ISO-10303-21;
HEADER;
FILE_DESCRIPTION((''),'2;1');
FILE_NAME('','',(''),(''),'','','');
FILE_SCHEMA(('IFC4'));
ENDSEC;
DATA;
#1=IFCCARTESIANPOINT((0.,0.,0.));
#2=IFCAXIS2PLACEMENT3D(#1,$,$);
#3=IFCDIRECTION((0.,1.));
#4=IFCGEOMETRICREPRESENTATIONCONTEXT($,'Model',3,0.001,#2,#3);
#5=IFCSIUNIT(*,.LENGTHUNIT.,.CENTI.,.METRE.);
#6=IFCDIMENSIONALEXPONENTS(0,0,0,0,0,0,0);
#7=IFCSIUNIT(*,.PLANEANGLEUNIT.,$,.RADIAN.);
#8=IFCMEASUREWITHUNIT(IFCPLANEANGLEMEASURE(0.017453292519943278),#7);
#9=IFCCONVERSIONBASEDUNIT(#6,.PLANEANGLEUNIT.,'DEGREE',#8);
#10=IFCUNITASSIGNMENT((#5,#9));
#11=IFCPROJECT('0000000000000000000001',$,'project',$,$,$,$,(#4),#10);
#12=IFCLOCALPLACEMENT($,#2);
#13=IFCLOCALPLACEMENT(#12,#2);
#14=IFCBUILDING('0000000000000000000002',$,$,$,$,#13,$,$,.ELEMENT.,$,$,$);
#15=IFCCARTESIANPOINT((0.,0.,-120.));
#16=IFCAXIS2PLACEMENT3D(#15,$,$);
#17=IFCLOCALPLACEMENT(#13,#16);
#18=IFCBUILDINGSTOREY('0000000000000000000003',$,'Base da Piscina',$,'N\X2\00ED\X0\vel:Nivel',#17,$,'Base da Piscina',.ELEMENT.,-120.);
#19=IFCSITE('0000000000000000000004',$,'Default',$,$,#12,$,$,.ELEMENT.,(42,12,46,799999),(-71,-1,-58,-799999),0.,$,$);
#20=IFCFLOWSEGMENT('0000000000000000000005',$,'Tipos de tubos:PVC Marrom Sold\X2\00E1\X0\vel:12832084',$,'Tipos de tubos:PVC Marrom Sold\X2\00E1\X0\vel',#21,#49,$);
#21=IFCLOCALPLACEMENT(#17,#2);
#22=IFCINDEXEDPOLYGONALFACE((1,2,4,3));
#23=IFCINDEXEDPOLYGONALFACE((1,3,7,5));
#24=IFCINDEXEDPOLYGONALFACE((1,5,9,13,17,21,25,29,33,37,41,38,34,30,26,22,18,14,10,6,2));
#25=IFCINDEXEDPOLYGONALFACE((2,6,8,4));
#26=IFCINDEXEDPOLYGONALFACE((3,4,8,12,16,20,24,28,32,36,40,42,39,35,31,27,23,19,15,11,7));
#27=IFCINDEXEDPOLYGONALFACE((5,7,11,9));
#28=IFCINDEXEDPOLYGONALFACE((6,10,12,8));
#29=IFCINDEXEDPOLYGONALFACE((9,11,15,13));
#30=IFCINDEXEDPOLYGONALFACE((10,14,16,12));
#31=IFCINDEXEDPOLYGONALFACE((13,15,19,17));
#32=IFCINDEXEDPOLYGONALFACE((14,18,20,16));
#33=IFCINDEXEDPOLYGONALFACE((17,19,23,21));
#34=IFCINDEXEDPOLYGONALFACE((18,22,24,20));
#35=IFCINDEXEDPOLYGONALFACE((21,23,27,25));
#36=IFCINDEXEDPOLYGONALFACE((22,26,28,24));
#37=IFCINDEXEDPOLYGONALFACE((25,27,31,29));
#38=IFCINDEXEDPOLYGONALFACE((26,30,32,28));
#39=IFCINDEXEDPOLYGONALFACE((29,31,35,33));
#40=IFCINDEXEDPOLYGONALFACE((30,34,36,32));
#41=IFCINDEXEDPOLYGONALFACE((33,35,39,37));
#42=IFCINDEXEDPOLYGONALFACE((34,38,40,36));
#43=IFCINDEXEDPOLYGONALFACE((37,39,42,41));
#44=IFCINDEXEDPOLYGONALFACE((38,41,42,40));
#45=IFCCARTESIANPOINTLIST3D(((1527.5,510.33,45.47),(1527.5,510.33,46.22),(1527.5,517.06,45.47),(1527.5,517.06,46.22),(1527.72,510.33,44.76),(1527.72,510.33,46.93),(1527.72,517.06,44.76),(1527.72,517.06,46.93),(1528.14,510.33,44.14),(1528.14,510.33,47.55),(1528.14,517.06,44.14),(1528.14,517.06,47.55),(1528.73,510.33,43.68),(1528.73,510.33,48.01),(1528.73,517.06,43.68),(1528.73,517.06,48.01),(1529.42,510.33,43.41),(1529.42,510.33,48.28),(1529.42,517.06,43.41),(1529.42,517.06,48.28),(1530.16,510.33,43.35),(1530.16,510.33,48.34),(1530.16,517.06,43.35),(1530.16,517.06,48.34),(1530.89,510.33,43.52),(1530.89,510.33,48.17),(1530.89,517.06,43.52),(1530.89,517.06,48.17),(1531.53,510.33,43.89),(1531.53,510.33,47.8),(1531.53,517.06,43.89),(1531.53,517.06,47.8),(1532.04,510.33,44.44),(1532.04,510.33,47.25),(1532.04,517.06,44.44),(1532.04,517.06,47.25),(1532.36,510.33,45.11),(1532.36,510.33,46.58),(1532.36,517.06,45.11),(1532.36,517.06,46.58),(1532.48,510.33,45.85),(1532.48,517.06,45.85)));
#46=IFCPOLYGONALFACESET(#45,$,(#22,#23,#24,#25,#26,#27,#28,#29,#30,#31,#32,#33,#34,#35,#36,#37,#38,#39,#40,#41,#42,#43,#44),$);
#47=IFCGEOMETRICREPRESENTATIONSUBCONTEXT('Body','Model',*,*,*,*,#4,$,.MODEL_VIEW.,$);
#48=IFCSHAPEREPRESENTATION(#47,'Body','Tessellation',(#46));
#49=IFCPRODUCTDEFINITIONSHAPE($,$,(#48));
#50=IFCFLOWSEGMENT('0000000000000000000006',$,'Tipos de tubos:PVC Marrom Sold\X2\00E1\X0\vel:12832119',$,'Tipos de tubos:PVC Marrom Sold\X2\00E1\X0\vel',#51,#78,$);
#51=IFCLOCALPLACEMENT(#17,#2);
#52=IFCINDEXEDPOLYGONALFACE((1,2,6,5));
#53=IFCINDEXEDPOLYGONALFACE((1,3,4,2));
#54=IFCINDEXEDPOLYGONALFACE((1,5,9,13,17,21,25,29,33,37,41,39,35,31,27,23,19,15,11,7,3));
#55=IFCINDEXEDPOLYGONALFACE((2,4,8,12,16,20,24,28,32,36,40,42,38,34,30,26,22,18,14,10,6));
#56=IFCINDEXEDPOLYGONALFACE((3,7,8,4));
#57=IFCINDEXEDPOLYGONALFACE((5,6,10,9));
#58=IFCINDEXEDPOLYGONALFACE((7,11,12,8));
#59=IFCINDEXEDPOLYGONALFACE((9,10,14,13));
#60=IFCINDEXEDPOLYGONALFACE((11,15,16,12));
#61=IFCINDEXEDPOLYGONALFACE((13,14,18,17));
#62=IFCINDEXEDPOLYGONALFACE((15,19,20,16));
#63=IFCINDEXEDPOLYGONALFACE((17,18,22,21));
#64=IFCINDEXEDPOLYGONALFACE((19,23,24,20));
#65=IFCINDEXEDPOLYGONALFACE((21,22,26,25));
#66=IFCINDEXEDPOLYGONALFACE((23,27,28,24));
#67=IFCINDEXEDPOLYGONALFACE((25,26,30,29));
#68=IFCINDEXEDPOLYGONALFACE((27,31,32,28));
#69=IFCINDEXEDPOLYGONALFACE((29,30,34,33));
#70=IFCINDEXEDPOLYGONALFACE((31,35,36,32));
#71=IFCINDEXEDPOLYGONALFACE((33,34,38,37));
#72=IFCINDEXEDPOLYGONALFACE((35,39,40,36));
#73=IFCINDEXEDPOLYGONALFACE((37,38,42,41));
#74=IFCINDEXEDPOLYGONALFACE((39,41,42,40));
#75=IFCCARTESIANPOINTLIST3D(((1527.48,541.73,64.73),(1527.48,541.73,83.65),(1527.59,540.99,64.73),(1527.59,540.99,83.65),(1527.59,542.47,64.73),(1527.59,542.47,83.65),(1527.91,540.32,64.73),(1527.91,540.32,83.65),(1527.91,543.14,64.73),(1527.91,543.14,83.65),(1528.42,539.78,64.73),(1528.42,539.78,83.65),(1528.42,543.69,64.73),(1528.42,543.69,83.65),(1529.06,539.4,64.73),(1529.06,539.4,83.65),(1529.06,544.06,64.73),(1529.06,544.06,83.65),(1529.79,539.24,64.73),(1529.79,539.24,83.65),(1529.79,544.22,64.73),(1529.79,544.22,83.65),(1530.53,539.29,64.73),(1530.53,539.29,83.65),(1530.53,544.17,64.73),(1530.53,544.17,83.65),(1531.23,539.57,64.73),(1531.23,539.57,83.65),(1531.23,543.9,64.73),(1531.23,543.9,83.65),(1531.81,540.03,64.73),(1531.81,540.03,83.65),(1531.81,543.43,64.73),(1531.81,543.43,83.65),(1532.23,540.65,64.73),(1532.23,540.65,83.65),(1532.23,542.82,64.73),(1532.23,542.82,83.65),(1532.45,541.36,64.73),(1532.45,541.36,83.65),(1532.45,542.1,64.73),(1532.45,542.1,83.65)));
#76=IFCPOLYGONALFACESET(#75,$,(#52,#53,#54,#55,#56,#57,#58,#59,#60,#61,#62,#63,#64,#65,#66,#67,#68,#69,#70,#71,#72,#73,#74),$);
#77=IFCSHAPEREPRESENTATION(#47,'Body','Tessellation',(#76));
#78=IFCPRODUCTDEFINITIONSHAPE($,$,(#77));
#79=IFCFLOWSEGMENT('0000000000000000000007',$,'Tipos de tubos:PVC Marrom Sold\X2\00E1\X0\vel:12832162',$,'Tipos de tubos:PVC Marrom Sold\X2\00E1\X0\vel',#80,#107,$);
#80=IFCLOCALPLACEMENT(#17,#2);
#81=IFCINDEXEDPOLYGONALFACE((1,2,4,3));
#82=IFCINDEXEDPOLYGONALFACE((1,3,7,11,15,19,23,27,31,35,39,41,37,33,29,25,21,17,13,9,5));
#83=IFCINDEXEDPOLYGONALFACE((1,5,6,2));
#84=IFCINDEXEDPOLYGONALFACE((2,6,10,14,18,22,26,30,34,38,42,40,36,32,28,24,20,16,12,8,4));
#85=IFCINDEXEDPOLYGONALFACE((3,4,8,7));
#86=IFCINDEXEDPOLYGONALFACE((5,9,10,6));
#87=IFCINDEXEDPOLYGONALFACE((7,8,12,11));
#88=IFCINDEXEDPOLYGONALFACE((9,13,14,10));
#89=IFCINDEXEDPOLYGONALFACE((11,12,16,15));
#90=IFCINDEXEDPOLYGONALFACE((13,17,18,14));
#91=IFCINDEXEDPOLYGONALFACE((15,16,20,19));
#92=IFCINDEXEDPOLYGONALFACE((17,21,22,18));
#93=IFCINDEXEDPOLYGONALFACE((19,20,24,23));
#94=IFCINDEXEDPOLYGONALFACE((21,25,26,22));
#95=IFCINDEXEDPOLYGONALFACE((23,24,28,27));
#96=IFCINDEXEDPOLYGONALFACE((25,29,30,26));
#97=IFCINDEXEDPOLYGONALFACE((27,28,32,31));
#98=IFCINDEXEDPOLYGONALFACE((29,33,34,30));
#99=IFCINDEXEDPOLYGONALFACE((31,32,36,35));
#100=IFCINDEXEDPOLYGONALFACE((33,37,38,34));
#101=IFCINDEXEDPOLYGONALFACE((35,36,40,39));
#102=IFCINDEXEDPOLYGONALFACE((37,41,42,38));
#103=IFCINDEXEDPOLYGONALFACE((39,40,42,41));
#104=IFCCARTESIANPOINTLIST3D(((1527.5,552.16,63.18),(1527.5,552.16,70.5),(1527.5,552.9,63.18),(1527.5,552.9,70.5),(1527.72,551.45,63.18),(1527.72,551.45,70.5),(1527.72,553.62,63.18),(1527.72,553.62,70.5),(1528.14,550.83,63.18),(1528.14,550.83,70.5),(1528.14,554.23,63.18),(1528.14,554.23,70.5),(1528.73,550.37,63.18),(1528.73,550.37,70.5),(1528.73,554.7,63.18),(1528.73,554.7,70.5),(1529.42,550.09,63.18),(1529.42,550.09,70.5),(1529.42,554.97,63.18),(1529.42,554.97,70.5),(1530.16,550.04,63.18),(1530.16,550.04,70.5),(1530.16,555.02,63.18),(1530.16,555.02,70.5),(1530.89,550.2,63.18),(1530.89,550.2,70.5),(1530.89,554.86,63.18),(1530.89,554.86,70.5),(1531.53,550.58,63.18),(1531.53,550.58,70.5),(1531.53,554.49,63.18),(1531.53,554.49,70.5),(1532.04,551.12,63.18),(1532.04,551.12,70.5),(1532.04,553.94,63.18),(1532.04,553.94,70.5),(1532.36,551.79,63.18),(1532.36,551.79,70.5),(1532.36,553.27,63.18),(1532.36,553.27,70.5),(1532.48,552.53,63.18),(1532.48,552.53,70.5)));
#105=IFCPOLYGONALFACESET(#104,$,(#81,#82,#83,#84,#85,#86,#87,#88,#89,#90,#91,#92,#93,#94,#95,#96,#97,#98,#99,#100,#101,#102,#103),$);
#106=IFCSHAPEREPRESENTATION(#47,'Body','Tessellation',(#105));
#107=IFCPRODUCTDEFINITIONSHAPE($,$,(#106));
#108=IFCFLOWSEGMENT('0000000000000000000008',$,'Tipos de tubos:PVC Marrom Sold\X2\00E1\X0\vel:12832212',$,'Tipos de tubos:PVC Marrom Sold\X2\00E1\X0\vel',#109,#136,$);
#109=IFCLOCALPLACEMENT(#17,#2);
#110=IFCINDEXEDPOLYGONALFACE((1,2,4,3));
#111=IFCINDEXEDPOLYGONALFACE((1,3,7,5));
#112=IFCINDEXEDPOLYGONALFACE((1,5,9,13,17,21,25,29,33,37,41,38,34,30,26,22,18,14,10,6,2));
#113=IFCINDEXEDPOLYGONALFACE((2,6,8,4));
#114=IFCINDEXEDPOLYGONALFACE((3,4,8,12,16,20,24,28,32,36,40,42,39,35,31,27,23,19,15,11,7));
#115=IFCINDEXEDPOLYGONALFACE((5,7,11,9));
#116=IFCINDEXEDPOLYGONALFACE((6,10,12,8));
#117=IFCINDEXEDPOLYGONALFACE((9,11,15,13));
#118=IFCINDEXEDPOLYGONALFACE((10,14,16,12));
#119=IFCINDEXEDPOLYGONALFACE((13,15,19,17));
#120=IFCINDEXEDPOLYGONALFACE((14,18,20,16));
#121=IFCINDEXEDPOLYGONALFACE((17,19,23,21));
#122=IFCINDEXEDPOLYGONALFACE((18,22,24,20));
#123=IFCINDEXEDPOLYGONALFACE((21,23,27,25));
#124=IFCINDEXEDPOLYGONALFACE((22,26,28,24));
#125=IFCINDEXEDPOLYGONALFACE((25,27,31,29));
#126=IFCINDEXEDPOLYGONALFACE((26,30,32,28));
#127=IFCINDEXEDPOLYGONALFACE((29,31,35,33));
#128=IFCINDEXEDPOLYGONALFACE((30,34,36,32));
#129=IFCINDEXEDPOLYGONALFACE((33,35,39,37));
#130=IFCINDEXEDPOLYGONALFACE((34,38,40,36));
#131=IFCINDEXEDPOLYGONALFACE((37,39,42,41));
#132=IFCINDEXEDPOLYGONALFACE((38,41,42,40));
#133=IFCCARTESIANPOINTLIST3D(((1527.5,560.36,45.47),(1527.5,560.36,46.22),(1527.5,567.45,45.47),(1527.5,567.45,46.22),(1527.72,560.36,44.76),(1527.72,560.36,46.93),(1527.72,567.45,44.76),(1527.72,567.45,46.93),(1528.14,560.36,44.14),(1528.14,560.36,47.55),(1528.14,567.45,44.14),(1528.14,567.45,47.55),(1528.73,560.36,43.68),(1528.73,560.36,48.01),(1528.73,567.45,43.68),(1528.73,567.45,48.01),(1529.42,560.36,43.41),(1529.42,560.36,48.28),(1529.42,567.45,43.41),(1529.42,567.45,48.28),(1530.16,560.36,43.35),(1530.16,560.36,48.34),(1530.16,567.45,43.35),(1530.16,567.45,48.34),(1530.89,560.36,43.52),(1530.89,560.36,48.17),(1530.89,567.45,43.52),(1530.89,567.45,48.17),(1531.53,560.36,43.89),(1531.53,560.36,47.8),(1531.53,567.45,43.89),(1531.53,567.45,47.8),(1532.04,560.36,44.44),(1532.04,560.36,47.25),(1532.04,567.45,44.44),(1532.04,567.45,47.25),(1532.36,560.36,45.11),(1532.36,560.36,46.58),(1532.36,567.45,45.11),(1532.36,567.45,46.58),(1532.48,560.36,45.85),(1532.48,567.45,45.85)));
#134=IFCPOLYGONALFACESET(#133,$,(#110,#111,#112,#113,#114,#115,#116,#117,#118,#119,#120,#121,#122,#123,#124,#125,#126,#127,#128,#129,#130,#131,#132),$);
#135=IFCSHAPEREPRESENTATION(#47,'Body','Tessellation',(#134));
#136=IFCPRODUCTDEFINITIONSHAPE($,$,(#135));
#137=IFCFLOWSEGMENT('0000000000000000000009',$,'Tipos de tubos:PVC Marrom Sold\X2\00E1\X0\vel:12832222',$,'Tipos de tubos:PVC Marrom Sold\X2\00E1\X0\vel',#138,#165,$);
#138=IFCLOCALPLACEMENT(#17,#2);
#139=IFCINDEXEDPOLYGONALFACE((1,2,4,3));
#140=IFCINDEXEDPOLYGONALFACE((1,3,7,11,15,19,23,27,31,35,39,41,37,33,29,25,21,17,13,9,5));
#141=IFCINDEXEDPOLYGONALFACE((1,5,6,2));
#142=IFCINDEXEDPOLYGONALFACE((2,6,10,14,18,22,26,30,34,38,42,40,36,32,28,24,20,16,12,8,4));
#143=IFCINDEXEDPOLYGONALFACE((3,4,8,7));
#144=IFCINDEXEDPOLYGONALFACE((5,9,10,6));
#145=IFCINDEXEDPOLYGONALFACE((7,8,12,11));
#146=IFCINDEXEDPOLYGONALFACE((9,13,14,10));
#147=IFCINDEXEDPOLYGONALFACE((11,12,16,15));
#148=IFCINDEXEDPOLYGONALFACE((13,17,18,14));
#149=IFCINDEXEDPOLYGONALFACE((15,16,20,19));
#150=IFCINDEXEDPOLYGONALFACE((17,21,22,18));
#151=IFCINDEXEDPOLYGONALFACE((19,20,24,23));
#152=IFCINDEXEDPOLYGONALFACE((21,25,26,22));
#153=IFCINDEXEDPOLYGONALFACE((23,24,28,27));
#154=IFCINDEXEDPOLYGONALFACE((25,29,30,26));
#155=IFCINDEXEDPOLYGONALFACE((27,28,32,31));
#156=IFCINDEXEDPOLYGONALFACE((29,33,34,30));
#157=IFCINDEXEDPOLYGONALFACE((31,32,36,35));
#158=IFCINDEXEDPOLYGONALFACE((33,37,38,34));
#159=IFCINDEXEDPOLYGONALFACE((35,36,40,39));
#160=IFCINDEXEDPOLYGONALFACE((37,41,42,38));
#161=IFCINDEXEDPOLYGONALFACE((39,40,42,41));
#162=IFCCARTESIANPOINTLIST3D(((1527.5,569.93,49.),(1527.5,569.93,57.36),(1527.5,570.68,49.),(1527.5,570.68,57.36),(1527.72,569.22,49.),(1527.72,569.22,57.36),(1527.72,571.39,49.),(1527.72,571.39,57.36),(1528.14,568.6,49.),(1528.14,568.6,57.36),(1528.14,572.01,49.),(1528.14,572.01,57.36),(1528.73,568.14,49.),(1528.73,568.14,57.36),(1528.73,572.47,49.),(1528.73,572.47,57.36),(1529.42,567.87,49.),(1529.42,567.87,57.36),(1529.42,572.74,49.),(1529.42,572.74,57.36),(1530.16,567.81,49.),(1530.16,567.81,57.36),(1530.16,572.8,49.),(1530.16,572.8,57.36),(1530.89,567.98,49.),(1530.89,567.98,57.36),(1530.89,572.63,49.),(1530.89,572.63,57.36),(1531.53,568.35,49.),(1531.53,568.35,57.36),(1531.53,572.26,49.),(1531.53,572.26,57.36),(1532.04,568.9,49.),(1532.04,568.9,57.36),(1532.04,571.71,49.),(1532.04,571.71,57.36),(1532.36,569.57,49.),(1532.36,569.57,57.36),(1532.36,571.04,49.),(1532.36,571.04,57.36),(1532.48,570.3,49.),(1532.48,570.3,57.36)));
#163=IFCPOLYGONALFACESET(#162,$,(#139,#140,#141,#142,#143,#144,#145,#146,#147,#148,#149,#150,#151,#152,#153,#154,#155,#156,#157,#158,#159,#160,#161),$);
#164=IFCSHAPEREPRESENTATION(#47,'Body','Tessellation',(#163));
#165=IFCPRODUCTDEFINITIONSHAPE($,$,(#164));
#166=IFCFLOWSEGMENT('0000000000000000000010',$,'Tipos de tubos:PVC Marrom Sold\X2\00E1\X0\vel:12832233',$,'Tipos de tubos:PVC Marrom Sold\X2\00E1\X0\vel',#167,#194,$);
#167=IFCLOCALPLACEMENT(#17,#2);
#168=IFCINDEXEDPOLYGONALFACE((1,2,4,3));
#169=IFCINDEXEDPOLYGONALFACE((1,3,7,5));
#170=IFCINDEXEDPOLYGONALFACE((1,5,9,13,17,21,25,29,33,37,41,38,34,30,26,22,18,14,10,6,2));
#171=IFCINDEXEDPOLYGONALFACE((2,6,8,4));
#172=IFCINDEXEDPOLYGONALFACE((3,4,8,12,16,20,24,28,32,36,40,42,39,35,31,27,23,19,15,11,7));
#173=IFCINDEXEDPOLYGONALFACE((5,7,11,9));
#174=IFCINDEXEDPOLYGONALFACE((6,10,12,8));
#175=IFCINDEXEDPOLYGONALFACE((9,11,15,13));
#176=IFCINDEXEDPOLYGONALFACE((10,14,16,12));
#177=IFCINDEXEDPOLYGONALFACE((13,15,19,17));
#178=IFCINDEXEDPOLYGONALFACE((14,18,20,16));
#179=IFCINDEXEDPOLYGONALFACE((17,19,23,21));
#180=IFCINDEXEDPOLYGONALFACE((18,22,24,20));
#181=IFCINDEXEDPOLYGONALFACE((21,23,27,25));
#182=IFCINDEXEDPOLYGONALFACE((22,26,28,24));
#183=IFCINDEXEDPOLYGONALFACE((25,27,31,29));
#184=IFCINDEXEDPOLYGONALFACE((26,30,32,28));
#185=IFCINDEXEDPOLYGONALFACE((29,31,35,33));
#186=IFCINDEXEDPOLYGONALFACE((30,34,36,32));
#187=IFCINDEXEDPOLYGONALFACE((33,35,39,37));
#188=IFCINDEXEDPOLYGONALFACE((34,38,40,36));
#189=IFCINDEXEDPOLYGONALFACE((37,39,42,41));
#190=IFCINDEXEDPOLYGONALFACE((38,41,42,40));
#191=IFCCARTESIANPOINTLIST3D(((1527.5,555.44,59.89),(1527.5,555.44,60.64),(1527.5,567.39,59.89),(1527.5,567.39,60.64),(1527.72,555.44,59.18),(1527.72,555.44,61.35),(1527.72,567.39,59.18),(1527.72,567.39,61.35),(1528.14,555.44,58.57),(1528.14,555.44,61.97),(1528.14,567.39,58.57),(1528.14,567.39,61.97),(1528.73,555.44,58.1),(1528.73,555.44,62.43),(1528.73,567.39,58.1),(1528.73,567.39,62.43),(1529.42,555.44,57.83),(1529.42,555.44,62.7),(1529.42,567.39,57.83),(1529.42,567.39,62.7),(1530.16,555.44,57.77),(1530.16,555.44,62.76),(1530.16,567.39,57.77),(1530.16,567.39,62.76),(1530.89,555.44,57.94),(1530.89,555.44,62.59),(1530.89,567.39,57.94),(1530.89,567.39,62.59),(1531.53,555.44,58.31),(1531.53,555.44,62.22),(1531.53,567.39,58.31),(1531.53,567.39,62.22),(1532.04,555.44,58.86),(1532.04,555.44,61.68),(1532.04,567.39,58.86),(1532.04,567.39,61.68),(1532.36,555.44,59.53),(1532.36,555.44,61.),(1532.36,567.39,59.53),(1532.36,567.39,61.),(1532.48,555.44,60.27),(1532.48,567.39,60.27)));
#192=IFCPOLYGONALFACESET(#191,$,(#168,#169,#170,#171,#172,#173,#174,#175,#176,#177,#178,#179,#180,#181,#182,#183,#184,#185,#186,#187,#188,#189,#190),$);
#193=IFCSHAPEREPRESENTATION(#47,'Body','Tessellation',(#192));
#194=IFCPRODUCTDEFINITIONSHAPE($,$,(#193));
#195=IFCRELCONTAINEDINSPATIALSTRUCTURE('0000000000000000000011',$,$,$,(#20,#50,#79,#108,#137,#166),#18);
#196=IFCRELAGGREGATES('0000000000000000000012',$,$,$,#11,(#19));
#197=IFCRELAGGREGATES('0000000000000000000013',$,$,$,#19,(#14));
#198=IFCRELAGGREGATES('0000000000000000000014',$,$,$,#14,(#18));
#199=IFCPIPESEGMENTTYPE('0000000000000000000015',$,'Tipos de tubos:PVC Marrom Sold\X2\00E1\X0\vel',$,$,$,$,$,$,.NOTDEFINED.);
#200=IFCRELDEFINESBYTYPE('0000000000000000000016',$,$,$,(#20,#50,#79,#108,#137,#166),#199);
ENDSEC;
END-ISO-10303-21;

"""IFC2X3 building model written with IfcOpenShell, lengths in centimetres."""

from ifc_helpers import new_model, entity, si_unit, converted_unit, direction, frame, frame_2d, origin, origin_2d_with_axis, place, context, subcontext, project, spatial, circle, extrude, type_object, element, save


model = new_model("IFC2X3")

# Units and contexts
model_context = context("Model", 3, precision=0.001, world=origin(), true_north=direction((0.0, 1.0)))
body_context = subcontext(model_context, "Body", "Model", "MODEL_VIEW")
ifc_project = project(units=[si_unit("LENGTHUNIT", "METRE", prefix="CENTI"), converted_unit("PLANEANGLEUNIT", "DEGREE", entity("IfcPlaneAngleMeasure", 0.017453292519943278), si_unit("PLANEANGLEUNIT", "RADIAN"), dimensions=[0, 0, 0, 0, 0, 0, 0])], contexts=[model_context])

# Site, building, storey
site_placement = place(None, origin())
site = spatial("IfcSite", under=ifc_project, at=site_placement, Name="Default", CompositionType="ELEMENT", RefLatitude=(42, 12, 46, 799999), RefLongitude=(-71, -1, -58, -799999), RefElevation=0.0)
building_placement = place(site_placement, origin())
building = spatial("IfcBuilding", under=site, at=building_placement, CompositionType="ELEMENT")
storey_placement = place(building_placement, frame((0.0, 0.0, -120.0)))
storey = spatial("IfcBuildingStorey", under=building, at=storey_placement, Name="Base da Piscina", ObjectType="Nível:Nivel", LongName="Base da Piscina", CompositionType="ELEMENT", Elevation=-120.0)

# Flow segments
pipe_segment_type = type_object("IfcPipeSegmentType", Name="Tipos de tubos:PVC Marrom Soldável", PredefinedType="NOTDEFINED")
flow_segment_1_placement = place(storey_placement, origin())
element("IfcFlowSegment", 1, at=flow_segment_1_placement, inside=storey, type_object=pipe_segment_type, Name="Tipos de tubos:PVC Marrom Soldável:12832084", ObjectType="Tipos de tubos:PVC Marrom Soldável", context=body_context, shape_type="SweptSolid", body=[
    extrude(circle(Radius=2.5, at=origin_2d_with_axis()), frame((1529.98, 510.33, 45.85), z_axis=(0.0, 1.0, 0.0), x_axis=(1.0, 0.0, 0.0)), (0.0, 0.0, 1.0), 6.74),
])
flow_segment_2_placement = place(storey_placement, origin())
element("IfcFlowSegment", 2, at=flow_segment_2_placement, inside=storey, type_object=pipe_segment_type, Name="Tipos de tubos:PVC Marrom Soldável:12832119", ObjectType="Tipos de tubos:PVC Marrom Soldável", context=body_context, shape_type="SweptSolid", body=[
    extrude(circle(Radius=2.5, at=origin_2d_with_axis()), frame((1529.98, 541.73, 64.73), z_axis=(0.0, 0.0, 1.0), x_axis=(-1.0, 0.0, 0.0)), (0.0, 0.0, 1.0), 18.91),
])
flow_segment_3_placement = place(storey_placement, origin())
element("IfcFlowSegment", 3, at=flow_segment_3_placement, inside=storey, type_object=pipe_segment_type, Name="Tipos de tubos:PVC Marrom Soldável:12832162", ObjectType="Tipos de tubos:PVC Marrom Soldável", context=body_context, shape_type="SweptSolid", body=[
    extrude(circle(Radius=2.5, at=origin_2d_with_axis()), frame((1529.98, 552.53, 63.18)), (0.0, 0.0, 1.0), 7.32),
])
flow_segment_4_placement = place(storey_placement, origin())
element("IfcFlowSegment", 4, at=flow_segment_4_placement, inside=storey, type_object=pipe_segment_type, Name="Tipos de tubos:PVC Marrom Soldável:12832212", ObjectType="Tipos de tubos:PVC Marrom Soldável", context=body_context, shape_type="SweptSolid", body=[
    extrude(circle(Radius=2.5, at=origin_2d_with_axis()), frame((1529.98, 560.36, 45.85), z_axis=(0.0, 1.0, 0.0), x_axis=(1.0, 0.0, 0.0)), (0.0, 0.0, 1.0), 7.09),
])
flow_segment_5_placement = place(storey_placement, origin())
element("IfcFlowSegment", 5, at=flow_segment_5_placement, inside=storey, type_object=pipe_segment_type, Name="Tipos de tubos:PVC Marrom Soldável:12832222", ObjectType="Tipos de tubos:PVC Marrom Soldável", context=body_context, shape_type="SweptSolid", body=[
    extrude(circle(Radius=2.5, at=frame_2d((0.0, 0.0), x_axis=(1.0, 0.0))), frame((1529.98, 570.3, 49.0)), (0.0, 0.0, 1.0), 8.36),
])
flow_segment_6_placement = place(storey_placement, origin())
element("IfcFlowSegment", 6, at=flow_segment_6_placement, inside=storey, type_object=pipe_segment_type, Name="Tipos de tubos:PVC Marrom Soldável:12832233", ObjectType="Tipos de tubos:PVC Marrom Soldável", context=body_context, shape_type="SweptSolid", body=[
    extrude(circle(Radius=2.5, at=frame_2d((0.0, 0.0), x_axis=(1.0, 0.0))), frame((1529.98, 555.44, 60.27), z_axis=(0.0, 1.0, 0.0), x_axis=(1.0, 0.0, 0.0)), (0.0, 0.0, 1.0), 11.95),
])

save(model, "model.ifc")
